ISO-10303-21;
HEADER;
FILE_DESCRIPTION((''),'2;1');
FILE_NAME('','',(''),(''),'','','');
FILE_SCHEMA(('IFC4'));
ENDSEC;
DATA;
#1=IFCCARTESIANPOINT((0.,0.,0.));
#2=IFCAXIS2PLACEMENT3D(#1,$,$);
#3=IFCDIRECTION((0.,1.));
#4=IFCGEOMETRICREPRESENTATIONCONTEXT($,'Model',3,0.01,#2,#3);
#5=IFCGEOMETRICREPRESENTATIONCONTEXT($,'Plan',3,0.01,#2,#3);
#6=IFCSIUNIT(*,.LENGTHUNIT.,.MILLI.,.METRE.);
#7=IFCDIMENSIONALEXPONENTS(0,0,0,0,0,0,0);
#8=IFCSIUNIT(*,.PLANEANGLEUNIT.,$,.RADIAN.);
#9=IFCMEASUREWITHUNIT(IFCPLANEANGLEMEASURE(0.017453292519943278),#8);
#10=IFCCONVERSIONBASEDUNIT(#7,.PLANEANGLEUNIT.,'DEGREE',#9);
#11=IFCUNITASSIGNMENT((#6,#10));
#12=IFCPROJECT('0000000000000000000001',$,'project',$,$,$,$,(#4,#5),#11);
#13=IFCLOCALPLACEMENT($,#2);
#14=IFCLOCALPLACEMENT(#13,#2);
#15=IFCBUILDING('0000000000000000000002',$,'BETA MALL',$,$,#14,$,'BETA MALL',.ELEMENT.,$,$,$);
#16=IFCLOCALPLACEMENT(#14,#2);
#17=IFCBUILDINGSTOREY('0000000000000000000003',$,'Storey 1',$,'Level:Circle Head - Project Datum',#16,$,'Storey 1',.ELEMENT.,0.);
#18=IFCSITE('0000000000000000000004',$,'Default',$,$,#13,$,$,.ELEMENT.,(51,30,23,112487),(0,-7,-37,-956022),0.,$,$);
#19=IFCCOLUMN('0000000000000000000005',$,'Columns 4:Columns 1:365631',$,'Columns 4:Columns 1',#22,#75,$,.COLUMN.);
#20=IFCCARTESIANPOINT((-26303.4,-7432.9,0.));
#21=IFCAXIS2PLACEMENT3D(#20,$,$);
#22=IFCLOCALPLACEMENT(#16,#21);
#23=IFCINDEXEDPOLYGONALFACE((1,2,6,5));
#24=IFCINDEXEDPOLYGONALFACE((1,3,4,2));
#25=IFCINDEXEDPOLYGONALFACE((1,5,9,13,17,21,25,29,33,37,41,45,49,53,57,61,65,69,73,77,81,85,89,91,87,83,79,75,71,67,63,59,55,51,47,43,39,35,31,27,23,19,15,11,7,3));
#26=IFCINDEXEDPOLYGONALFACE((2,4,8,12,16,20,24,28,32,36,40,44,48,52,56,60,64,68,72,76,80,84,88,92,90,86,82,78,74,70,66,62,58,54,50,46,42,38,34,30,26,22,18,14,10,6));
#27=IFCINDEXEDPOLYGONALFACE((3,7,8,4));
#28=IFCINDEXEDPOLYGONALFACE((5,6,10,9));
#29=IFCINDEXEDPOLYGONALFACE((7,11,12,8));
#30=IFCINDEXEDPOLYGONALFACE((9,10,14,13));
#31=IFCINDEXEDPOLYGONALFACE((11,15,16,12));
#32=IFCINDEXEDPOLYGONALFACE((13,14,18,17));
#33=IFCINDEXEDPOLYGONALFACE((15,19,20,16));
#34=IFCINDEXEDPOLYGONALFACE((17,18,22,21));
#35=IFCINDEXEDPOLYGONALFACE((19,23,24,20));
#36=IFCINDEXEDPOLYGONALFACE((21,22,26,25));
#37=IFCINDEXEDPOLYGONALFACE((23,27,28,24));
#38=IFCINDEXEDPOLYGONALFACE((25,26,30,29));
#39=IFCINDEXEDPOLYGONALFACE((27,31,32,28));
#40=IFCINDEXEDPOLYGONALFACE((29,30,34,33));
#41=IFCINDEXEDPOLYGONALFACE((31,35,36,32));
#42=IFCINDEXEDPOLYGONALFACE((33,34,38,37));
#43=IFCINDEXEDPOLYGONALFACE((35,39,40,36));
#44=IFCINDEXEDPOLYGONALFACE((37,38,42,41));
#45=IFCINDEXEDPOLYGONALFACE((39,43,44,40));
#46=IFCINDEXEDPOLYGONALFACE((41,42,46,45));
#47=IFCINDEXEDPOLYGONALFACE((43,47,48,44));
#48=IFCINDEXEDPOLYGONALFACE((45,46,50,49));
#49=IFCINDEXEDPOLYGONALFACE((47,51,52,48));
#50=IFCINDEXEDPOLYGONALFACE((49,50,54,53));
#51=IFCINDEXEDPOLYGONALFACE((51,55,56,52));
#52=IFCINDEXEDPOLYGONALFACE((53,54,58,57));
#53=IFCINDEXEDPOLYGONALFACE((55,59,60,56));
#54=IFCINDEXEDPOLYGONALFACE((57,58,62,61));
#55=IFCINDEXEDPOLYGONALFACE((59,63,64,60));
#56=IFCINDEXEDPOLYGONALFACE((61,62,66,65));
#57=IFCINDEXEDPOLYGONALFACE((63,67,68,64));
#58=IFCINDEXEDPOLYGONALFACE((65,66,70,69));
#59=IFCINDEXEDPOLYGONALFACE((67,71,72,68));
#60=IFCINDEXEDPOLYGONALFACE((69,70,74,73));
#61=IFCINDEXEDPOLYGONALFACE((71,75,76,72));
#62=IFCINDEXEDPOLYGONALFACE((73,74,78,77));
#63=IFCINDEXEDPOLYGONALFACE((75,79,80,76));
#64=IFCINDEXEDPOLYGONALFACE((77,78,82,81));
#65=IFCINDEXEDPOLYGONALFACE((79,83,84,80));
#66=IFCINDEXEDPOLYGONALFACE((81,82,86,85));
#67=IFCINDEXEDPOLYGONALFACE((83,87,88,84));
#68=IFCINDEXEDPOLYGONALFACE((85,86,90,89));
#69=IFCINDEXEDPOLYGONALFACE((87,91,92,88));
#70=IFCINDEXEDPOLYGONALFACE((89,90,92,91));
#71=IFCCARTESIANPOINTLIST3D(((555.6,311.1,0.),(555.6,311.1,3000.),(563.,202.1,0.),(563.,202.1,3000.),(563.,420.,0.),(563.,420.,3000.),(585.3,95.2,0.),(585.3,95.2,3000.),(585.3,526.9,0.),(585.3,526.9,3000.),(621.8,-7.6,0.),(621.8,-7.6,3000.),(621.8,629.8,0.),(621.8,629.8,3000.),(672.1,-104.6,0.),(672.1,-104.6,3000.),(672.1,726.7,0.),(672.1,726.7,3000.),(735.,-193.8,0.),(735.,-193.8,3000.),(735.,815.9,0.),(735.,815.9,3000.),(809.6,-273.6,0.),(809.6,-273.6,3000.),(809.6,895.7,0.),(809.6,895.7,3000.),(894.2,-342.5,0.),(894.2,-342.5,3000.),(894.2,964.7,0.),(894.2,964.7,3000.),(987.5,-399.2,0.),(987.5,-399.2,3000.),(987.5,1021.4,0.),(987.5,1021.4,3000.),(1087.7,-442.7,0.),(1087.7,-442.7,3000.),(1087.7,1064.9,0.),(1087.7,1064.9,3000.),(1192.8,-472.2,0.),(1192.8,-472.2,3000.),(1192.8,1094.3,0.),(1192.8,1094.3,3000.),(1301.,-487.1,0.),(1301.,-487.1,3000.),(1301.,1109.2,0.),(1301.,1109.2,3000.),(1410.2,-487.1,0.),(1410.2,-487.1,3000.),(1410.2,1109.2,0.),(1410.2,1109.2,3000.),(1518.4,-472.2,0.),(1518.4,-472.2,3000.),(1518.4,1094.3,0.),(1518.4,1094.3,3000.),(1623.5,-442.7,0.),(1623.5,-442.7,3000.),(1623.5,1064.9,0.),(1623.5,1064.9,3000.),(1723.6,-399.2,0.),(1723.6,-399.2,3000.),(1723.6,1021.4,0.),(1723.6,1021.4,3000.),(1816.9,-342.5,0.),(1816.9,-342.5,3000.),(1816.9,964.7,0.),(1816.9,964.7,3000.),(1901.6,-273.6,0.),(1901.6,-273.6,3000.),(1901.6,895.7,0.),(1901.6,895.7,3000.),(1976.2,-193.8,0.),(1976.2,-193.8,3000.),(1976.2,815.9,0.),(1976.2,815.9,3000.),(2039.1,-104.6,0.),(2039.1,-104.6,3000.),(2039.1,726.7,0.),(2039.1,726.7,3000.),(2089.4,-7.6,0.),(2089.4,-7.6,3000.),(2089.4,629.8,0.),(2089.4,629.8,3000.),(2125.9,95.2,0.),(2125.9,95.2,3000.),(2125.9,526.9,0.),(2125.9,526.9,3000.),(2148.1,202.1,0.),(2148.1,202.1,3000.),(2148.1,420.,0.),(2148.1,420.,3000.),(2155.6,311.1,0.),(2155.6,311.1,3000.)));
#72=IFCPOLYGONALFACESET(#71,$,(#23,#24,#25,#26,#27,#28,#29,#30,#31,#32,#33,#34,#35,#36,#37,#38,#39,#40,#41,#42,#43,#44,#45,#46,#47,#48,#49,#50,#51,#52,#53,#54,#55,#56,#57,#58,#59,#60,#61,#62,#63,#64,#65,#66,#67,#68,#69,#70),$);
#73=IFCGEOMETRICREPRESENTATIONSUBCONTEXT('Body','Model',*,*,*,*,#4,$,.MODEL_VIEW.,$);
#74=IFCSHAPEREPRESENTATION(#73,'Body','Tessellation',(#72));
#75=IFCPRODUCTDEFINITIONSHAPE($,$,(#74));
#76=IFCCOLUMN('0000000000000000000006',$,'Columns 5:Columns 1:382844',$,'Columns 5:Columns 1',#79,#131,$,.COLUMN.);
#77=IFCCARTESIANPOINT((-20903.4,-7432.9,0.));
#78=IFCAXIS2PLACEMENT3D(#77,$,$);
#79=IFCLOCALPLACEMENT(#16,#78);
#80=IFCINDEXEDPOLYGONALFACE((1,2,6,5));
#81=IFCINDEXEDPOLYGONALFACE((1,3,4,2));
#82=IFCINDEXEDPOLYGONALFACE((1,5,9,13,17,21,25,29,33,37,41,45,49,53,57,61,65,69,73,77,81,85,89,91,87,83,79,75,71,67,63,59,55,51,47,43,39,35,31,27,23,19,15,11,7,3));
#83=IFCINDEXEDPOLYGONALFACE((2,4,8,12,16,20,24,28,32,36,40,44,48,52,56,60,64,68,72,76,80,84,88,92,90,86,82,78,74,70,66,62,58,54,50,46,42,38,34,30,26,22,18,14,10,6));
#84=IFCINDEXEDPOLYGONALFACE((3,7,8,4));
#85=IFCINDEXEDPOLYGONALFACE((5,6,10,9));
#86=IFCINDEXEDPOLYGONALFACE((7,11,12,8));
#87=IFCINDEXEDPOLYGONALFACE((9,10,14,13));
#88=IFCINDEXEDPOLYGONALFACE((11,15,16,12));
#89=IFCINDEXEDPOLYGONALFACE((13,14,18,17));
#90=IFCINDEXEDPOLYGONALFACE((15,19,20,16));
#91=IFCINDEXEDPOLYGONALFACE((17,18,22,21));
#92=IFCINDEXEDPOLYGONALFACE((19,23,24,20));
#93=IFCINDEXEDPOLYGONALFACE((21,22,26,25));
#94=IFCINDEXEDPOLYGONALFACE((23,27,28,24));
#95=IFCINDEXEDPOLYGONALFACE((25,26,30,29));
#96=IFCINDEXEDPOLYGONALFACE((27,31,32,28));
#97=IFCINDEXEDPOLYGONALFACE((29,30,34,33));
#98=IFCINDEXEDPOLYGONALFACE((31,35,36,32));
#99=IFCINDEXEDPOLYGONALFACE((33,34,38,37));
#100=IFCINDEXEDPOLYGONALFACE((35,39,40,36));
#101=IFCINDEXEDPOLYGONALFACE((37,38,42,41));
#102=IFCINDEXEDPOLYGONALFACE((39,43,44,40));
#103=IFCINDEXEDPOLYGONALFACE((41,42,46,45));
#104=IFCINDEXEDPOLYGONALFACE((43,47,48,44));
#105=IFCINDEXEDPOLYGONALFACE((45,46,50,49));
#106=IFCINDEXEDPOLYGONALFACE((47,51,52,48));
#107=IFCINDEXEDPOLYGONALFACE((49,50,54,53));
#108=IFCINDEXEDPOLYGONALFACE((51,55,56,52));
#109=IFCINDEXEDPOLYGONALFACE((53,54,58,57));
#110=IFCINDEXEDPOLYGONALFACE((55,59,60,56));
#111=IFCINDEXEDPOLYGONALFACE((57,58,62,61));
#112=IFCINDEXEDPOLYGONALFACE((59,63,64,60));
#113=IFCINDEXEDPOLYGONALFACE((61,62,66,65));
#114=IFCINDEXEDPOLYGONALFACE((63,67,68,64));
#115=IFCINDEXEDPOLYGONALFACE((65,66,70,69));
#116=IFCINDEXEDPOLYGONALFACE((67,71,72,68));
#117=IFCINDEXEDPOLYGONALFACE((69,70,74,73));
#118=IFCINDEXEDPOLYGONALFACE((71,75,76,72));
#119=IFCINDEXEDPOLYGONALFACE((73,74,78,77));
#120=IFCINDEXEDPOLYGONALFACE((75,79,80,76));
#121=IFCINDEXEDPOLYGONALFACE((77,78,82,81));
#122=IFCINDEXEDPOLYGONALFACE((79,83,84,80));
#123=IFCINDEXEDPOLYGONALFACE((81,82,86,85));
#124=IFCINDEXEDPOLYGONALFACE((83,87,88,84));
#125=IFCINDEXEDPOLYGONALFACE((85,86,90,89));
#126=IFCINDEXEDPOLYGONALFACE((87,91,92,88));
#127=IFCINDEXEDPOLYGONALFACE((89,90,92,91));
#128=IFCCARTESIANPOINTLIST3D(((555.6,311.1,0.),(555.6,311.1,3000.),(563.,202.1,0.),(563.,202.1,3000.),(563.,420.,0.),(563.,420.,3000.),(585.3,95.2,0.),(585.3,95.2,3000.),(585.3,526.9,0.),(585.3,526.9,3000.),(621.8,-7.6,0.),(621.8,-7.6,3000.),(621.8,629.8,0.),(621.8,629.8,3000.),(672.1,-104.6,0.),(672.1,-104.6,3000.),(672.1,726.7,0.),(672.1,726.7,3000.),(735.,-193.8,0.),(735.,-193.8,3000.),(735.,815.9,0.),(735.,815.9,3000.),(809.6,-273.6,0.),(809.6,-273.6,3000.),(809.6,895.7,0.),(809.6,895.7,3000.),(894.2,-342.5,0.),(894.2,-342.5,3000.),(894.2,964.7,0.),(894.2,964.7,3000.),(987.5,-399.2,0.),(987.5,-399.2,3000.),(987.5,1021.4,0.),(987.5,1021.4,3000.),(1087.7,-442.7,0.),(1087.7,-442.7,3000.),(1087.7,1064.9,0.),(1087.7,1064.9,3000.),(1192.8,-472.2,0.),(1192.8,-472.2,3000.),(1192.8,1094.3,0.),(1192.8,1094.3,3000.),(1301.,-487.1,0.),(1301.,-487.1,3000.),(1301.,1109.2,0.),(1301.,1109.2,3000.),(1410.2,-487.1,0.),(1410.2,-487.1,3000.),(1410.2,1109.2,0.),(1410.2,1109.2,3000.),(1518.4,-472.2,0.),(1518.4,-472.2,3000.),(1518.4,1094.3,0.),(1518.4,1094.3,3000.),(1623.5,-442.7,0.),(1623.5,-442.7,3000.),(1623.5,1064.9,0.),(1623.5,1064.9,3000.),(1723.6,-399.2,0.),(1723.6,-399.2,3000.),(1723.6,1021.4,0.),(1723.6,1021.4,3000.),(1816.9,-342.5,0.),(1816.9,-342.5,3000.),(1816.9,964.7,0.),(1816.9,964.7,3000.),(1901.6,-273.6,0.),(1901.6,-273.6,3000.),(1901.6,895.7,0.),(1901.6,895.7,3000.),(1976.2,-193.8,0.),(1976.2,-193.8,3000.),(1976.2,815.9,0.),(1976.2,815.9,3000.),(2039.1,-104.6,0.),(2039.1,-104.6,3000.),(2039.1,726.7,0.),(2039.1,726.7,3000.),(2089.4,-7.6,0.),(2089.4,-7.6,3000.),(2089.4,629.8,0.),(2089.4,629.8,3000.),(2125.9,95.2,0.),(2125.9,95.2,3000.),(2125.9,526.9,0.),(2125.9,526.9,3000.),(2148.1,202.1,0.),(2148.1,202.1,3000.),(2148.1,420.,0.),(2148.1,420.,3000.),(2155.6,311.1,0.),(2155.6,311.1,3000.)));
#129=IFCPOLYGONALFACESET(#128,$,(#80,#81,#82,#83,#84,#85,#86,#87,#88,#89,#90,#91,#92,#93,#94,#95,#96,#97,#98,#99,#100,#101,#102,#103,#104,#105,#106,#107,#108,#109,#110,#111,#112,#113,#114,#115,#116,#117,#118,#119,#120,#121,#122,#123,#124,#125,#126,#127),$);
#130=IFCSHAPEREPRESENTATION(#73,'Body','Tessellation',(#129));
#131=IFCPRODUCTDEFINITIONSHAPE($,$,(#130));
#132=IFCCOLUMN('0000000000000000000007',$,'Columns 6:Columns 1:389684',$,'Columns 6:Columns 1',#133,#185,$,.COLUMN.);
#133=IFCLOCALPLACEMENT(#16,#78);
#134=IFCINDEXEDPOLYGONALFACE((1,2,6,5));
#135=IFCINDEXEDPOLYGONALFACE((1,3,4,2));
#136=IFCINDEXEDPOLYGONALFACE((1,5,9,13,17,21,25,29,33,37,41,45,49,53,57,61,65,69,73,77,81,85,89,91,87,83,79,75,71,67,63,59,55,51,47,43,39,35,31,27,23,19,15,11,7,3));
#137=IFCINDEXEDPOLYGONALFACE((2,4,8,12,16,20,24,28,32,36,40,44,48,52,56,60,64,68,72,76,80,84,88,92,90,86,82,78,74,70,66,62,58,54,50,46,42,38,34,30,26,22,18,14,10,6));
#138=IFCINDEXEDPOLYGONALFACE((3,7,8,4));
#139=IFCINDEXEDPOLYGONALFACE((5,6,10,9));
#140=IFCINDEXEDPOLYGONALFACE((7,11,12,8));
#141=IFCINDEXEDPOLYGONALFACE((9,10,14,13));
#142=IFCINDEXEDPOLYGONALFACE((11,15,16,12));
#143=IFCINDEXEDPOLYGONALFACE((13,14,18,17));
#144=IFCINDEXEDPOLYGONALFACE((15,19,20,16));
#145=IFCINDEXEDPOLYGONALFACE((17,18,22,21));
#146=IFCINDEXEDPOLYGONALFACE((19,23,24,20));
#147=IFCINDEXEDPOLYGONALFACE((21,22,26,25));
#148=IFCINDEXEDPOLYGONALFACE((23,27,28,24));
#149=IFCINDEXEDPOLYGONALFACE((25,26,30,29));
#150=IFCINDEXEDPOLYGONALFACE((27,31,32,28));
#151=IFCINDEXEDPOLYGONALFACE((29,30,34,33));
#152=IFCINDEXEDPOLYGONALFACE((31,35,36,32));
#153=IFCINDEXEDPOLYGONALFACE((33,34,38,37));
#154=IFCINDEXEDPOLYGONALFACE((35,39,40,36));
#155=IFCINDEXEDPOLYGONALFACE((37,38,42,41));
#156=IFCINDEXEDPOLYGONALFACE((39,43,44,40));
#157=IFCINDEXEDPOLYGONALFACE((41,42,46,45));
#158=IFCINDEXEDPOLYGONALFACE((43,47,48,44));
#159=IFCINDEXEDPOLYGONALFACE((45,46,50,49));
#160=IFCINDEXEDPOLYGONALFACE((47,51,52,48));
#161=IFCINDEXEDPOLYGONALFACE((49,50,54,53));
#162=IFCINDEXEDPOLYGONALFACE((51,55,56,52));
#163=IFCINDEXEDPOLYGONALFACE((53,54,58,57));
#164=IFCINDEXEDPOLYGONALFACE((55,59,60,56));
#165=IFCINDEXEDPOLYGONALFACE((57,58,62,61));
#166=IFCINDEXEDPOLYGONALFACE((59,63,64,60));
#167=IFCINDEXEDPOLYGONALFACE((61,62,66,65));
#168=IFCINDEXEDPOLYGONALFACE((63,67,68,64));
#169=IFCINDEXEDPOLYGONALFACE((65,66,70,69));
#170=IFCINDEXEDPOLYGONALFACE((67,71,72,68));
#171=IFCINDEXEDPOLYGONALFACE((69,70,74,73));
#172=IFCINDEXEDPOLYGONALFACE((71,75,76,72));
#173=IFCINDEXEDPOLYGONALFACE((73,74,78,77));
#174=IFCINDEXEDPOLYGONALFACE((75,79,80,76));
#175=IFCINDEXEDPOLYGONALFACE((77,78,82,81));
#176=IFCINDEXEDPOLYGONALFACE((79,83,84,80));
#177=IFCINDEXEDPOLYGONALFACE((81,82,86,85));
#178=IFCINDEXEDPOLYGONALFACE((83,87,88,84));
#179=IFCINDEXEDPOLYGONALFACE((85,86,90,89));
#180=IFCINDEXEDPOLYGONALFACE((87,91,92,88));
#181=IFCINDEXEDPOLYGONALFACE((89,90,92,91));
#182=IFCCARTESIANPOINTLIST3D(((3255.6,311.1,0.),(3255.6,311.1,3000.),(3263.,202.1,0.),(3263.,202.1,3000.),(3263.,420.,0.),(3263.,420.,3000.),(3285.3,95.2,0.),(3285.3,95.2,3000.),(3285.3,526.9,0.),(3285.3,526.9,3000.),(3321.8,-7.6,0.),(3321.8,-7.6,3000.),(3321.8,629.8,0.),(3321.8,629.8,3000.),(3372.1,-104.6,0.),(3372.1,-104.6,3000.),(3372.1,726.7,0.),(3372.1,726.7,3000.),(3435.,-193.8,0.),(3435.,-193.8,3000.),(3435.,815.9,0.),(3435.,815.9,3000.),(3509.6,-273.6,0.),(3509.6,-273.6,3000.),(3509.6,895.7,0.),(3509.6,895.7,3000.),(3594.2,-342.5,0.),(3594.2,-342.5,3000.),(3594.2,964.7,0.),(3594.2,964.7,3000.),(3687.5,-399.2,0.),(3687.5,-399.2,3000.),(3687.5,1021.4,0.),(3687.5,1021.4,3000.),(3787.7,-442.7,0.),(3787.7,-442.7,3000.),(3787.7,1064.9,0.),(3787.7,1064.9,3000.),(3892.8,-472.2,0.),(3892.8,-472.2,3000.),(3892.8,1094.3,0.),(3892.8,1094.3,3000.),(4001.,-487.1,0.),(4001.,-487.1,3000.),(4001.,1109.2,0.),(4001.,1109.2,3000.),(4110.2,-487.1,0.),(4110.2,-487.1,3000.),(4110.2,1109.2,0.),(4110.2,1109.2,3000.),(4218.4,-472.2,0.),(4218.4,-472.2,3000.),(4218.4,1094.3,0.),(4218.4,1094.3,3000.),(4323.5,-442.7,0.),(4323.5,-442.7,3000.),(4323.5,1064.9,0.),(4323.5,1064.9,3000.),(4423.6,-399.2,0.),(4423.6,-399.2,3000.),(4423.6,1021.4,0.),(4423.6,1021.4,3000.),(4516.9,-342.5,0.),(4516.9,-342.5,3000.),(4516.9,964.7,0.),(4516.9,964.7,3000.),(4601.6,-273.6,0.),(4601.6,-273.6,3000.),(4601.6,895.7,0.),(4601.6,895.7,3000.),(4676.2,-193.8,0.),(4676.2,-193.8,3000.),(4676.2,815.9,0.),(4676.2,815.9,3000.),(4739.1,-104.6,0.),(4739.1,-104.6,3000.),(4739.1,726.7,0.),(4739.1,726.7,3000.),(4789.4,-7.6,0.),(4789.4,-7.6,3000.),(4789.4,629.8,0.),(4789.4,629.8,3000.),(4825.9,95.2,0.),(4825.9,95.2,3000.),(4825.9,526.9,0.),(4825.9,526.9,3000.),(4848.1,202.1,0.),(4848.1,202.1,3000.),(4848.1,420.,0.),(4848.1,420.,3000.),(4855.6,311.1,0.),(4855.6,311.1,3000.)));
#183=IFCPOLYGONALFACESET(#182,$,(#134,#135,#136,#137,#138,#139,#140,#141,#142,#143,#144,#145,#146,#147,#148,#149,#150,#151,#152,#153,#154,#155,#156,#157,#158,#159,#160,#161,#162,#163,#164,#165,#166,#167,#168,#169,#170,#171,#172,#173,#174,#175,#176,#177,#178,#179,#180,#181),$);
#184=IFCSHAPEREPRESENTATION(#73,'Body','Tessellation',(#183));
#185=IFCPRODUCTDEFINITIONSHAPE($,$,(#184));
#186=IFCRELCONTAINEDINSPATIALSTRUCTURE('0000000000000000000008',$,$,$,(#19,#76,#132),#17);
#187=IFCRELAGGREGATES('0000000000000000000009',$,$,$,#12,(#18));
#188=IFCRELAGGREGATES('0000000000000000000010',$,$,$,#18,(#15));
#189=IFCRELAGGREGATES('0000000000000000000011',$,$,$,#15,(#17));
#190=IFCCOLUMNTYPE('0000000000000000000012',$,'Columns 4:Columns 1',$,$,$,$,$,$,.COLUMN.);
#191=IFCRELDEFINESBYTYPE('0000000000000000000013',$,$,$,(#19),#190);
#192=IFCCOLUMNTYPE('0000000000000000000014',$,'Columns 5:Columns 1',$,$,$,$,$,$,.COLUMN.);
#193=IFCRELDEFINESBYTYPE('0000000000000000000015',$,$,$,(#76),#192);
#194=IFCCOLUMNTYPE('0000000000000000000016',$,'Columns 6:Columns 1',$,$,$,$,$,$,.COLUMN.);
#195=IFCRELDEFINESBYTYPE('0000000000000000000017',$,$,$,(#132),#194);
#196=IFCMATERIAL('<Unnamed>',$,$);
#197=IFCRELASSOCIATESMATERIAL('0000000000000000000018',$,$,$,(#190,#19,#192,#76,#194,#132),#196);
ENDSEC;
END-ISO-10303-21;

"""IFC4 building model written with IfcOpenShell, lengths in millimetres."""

from ifc_helpers import new_model, entity, si_unit, converted_unit, direction, frame, origin, place, context, subcontext, project, spatial, arc, indexed_curve, outline, extrude, source, transform, mapped, material, type_object, type_shapes, element, save


model = new_model("IFC4")

# Units and contexts
model_context = context("Model", 3, precision=0.01, world=origin(), true_north=direction((0.0, 1.0)))
plan_context = context("Plan", 3, precision=0.01, world=origin(), true_north=direction((0.0, 1.0)))
body_context = subcontext(model_context, "Body", "Model", "MODEL_VIEW")
ifc_project = project(units=[si_unit("LENGTHUNIT", "METRE", prefix="MILLI"), converted_unit("PLANEANGLEUNIT", "DEGREE", entity("IfcPlaneAngleMeasure", 0.017453292519943278), si_unit("PLANEANGLEUNIT", "RADIAN"), dimensions=[0, 0, 0, 0, 0, 0, 0])], contexts=[model_context, plan_context])

# Site, building, storey
site_placement = place(None, origin())
site = spatial("IfcSite", under=ifc_project, at=site_placement, Name="Default", CompositionType="ELEMENT", RefLatitude=(51, 30, 23, 112487), RefLongitude=(0, -7, -37, -956022), RefElevation=0.0)
building_placement = place(site_placement, origin())
building = spatial("IfcBuilding", under=site, at=building_placement, Name="BETA MALL", LongName="BETA MALL", CompositionType="ELEMENT")
storey_placement = place(building_placement, origin())
storey = spatial("IfcBuildingStorey", under=building, at=storey_placement, Name="Storey 1", ObjectType="Level:Circle Head - Project Datum", LongName="Storey 1", CompositionType="ELEMENT", Elevation=0.0)

# Columns
ifc_material_1 = material(Name="<Unnamed>")
column_type_1 = type_object("IfcColumnType", Name="Columns 4:Columns 1", PredefinedType="COLUMN", material=ifc_material_1)
shared_shape_1 = source(origin(), body_context, "Body", "SweptSolid", [
    extrude(outline(indexed_curve([(-800.0, 0.0), (0.0, -800.0), (800.0, 0.0), (0.0, 800.0)], segments=[arc(1, 2, 3), arc(3, 4, 1)], self_intersect=False)), frame((1355.6, 311.1, 0.0)), (0.0, 0.0, 1.0), 3000.0),
])
type_shapes(column_type_1, [shared_shape_1])
column_1_placement = place(storey_placement, frame((-26303.4, -7432.9, 0.0)))
element("IfcColumn", 1, at=column_1_placement, inside=storey, type_object=column_type_1, material=ifc_material_1, Name="Columns 4:Columns 1:365631", ObjectType="Columns 4:Columns 1", PredefinedType="COLUMN", context=body_context, shape_type="MappedRepresentation", body=[
    mapped(shared_shape_1, transform((0.0, 0.0, 0.0), scale=1.0)),
])
column_type_2 = type_object("IfcColumnType", Name="Columns 5:Columns 1", PredefinedType="COLUMN", material=ifc_material_1)
shared_shape_2 = source(origin(), body_context, "Body", "SweptSolid", [
    extrude(outline(indexed_curve([(-800.0, 0.0), (0.0, -800.0), (800.0, 0.0), (0.0, 800.0)], segments=[arc(1, 2, 3), arc(3, 4, 1)], self_intersect=False)), frame((1355.6, 311.1, 0.0)), (0.0, 0.0, 1.0), 3000.0),
])
type_shapes(column_type_2, [shared_shape_2])
column_2_placement = place(storey_placement, frame((-20903.4, -7432.9, 0.0)))
element("IfcColumn", 2, at=column_2_placement, inside=storey, type_object=column_type_2, material=ifc_material_1, Name="Columns 5:Columns 1:382844", ObjectType="Columns 5:Columns 1", PredefinedType="COLUMN", context=body_context, shape_type="MappedRepresentation", body=[
    mapped(shared_shape_2, transform((0.0, 0.0, 0.0), scale=1.0)),
])
column_type_3 = type_object("IfcColumnType", Name="Columns 6:Columns 1", PredefinedType="COLUMN", material=ifc_material_1)
shared_shape_3 = source(origin(), body_context, "Body", "SweptSolid", [
    extrude(outline(indexed_curve([(-800.0, 0.0), (0.0, -800.0), (800.0, 0.0), (0.0, 800.0)], segments=[arc(1, 2, 3), arc(3, 4, 1)], self_intersect=False)), frame((4055.6, 311.1, 0.0)), (0.0, 0.0, 1.0), 3000.0),
])
type_shapes(column_type_3, [shared_shape_3])
column_3_placement = place(storey_placement, frame((-20903.4, -7432.9, 0.0)))
element("IfcColumn", 3, at=column_3_placement, inside=storey, type_object=column_type_3, material=ifc_material_1, Name="Columns 6:Columns 1:389684", ObjectType="Columns 6:Columns 1", PredefinedType="COLUMN", context=body_context, shape_type="MappedRepresentation", body=[
    mapped(shared_shape_3, transform((0.0, 0.0, 0.0), scale=1.0)),
])

save(model, "model.ifc")
